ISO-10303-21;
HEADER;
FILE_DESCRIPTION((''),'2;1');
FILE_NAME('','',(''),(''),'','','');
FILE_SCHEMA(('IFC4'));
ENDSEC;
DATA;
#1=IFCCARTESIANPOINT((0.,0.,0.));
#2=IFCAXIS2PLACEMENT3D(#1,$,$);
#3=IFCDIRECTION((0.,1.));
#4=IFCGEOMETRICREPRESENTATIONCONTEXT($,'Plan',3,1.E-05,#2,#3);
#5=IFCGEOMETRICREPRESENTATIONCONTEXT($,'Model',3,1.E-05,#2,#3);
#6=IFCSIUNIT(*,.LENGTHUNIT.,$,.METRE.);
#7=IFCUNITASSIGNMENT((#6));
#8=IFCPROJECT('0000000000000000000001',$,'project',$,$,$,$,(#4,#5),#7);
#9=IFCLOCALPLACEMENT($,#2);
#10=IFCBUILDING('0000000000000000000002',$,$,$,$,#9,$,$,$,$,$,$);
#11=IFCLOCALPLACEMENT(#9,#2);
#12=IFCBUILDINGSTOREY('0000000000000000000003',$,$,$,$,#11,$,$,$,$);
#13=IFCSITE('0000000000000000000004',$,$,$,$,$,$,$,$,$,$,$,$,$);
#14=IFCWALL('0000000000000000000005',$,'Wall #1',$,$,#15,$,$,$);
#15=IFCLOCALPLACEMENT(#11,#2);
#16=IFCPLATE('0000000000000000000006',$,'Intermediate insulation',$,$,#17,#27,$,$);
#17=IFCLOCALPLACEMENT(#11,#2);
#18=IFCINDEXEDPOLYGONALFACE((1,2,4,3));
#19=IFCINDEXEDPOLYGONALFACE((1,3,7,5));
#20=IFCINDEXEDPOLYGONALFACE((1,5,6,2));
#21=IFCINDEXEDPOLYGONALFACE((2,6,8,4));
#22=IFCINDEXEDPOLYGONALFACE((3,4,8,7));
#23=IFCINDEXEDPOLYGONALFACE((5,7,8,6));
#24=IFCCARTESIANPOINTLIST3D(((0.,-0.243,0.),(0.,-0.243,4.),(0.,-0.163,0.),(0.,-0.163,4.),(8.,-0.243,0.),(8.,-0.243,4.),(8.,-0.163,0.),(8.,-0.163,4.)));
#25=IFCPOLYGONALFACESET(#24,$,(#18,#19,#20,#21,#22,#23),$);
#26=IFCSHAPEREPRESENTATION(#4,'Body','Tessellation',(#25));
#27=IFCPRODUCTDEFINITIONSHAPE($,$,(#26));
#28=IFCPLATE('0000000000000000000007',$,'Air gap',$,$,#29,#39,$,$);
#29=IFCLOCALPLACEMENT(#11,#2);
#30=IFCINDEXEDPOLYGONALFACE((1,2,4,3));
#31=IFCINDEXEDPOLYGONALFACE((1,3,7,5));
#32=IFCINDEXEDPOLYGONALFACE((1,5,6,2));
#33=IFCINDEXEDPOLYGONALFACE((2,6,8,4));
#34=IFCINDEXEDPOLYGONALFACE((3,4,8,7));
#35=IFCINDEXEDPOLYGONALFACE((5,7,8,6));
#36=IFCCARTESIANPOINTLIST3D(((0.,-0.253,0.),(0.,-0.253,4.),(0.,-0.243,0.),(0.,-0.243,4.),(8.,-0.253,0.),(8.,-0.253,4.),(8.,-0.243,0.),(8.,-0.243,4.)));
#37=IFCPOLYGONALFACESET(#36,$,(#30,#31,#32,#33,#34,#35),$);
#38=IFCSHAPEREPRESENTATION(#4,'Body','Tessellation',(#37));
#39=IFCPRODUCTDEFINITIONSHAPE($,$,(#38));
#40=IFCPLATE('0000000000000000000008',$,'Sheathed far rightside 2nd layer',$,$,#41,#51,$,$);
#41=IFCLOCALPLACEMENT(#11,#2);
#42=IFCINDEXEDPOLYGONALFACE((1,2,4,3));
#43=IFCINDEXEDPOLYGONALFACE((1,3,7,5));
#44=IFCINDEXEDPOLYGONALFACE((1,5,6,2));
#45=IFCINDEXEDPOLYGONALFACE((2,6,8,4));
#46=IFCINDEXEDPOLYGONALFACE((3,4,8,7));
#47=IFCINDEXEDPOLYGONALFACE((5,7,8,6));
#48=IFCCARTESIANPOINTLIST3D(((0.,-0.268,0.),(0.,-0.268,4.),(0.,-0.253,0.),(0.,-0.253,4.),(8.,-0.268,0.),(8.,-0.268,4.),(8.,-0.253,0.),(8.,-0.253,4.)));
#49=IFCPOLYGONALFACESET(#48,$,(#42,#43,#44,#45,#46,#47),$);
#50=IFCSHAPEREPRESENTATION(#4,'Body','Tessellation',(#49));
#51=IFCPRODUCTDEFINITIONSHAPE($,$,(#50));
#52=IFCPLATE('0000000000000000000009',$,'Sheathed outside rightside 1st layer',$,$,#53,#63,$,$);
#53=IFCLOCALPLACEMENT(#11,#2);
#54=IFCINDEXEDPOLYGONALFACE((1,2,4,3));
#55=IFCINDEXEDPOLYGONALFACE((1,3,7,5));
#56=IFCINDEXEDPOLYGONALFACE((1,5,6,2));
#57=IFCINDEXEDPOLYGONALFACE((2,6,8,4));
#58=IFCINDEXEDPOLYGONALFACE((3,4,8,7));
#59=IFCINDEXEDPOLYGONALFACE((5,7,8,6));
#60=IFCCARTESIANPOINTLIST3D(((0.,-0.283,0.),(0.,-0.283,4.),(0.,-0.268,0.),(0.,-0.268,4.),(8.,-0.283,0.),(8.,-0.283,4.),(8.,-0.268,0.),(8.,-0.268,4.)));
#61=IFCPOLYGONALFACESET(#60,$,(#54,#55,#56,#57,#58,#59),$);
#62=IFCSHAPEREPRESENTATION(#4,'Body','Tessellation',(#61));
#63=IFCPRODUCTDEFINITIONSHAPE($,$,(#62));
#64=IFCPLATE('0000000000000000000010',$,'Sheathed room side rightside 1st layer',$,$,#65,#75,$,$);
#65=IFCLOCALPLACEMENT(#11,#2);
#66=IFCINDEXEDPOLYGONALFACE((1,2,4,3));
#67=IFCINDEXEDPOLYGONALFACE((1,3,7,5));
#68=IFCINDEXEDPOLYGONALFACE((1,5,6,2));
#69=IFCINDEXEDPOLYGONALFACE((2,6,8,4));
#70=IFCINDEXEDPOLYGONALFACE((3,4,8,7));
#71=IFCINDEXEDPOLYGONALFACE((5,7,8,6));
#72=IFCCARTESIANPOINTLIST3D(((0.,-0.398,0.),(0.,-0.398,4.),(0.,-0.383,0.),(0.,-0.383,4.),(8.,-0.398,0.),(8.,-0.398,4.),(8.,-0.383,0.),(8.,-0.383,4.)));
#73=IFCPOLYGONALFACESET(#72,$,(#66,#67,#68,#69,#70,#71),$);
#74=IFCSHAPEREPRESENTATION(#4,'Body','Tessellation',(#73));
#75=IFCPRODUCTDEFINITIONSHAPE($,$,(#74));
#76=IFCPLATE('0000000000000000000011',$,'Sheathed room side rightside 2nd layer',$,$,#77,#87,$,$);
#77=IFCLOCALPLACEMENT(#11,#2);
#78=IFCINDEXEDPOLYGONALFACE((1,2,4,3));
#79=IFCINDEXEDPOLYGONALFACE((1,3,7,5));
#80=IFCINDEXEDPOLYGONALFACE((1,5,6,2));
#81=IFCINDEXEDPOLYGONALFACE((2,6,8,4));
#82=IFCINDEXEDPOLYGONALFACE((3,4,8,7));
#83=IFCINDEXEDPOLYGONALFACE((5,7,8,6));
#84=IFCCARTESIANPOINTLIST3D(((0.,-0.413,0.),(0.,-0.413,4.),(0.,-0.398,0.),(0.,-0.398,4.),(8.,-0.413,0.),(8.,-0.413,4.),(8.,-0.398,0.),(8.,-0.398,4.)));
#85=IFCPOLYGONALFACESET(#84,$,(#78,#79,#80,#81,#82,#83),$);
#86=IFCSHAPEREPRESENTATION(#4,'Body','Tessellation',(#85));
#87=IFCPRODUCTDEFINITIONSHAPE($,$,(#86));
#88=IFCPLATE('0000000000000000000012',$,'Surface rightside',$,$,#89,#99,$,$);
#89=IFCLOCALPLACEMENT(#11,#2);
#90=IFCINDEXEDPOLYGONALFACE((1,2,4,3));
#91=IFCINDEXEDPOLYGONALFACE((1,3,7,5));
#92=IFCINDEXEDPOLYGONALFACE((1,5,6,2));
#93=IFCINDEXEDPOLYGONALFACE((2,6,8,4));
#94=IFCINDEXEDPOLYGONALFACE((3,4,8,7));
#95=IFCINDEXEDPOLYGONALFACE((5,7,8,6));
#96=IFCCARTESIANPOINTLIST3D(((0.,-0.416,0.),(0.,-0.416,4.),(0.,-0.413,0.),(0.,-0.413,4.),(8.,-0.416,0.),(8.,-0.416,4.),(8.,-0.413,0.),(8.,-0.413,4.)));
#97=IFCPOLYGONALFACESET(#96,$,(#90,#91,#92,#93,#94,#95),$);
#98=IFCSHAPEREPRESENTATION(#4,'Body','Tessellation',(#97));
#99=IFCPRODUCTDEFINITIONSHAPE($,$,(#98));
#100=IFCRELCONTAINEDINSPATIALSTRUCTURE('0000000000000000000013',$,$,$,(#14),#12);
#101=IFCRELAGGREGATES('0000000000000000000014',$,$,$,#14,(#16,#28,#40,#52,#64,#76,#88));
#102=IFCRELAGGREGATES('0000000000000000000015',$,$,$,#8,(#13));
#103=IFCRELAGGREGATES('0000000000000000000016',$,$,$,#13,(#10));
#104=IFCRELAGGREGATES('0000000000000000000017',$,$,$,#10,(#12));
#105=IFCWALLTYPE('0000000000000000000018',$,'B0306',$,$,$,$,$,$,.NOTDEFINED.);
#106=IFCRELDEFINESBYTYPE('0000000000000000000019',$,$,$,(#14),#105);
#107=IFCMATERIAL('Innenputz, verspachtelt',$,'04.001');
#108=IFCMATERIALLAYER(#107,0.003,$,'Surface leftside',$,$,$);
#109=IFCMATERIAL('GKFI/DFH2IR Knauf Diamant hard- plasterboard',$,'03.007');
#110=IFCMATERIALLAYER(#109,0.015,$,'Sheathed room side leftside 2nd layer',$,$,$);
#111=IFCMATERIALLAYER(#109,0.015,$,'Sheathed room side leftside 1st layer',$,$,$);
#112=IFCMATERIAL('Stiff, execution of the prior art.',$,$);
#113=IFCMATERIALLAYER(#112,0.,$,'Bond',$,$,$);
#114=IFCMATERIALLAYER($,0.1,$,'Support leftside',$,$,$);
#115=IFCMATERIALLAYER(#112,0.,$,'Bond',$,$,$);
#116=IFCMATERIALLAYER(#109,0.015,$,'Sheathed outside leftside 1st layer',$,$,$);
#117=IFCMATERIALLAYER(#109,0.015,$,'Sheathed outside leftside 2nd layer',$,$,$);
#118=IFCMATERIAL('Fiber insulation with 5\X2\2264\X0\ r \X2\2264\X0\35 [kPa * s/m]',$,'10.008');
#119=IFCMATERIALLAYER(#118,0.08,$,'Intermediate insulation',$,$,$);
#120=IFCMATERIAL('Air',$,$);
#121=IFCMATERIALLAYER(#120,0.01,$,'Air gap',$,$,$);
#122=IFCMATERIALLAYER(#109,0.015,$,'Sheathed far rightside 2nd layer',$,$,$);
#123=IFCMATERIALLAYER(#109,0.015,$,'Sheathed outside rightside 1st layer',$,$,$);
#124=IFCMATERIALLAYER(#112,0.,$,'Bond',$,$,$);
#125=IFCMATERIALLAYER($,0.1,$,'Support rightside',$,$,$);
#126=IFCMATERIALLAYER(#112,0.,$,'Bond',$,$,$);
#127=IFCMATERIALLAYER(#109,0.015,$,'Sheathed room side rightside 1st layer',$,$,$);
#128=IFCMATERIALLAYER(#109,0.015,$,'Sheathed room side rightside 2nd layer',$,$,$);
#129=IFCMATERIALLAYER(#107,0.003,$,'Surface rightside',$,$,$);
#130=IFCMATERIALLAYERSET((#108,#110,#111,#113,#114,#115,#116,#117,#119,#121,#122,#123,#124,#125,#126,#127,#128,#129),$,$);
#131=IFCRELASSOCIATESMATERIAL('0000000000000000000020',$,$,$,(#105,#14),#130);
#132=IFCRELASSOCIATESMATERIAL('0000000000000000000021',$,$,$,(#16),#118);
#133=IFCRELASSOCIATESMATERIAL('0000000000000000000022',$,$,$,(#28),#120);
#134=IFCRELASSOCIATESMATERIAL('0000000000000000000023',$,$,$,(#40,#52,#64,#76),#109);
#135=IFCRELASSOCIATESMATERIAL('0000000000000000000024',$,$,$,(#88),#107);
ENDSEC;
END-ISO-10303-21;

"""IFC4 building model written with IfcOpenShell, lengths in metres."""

from ifc_helpers import new_model, si_unit, direction, frame, frame_2d, origin, place, context, project, spatial, rectangle, extrude, material, layer, layer_set, type_object, element, aggregate, save


model = new_model("IFC4")

# Units and contexts
plan_context = context("Plan", 3, precision=1e-05, world=origin(), true_north=direction((0.0, 1.0)))
model_context = context("Model", 3, precision=1e-05, world=origin(), true_north=direction((0.0, 1.0)))
ifc_project = project(units=[si_unit("LENGTHUNIT", "METRE")], contexts=[plan_context, model_context])

# Site, building, storey
site = spatial("IfcSite", under=ifc_project)
building_placement = place(None, origin())
building = spatial("IfcBuilding", under=site, at=building_placement)
storey_placement = place(building_placement, origin())
storey = spatial("IfcBuildingStorey", under=building, at=storey_placement)

# Wall, plates
ifc_material_1 = material(Name="Innenputz, verspachtelt", Category="04.001")
ifc_layer_1 = layer(ifc_material_1, 0.003, Name="Surface leftside")
ifc_material_2 = material(Name="GKFI/DFH2IR Knauf Diamant hard- plasterboard", Category="03.007")
ifc_layer_2 = layer(ifc_material_2, 0.015, Name="Sheathed room side leftside 2nd layer")
ifc_layer_3 = layer(ifc_material_2, 0.015, Name="Sheathed room side leftside 1st layer")
ifc_material_3 = material(Name="Stiff, execution of the prior art.")
ifc_layer_4 = layer(ifc_material_3, 0.0, Name="Bond")
ifc_layer_5 = layer(None, 0.1, Name="Support leftside")
ifc_layer_6 = layer(ifc_material_3, 0.0, Name="Bond")
ifc_layer_7 = layer(ifc_material_2, 0.015, Name="Sheathed outside leftside 1st layer")
ifc_layer_8 = layer(ifc_material_2, 0.015, Name="Sheathed outside leftside 2nd layer")
ifc_material_4 = material(Name="Fiber insulation with 5≤ r ≤35 [kPa * s/m]", Category="10.008")
ifc_layer_9 = layer(ifc_material_4, 0.08, Name="Intermediate insulation")
ifc_material_5 = material(Name="Air")
ifc_layer_10 = layer(ifc_material_5, 0.01, Name="Air gap")
ifc_layer_11 = layer(ifc_material_2, 0.015, Name="Sheathed far rightside 2nd layer")
ifc_layer_12 = layer(ifc_material_2, 0.015, Name="Sheathed outside rightside 1st layer")
ifc_layer_13 = layer(ifc_material_3, 0.0, Name="Bond")
ifc_layer_14 = layer(None, 0.1, Name="Support rightside")
ifc_layer_15 = layer(ifc_material_3, 0.0, Name="Bond")
ifc_layer_16 = layer(ifc_material_2, 0.015, Name="Sheathed room side rightside 1st layer")
ifc_layer_17 = layer(ifc_material_2, 0.015, Name="Sheathed room side rightside 2nd layer")
ifc_layer_18 = layer(ifc_material_1, 0.003, Name="Surface rightside")
ifc_layer_set = layer_set([ifc_layer_1, ifc_layer_2, ifc_layer_3, ifc_layer_4, ifc_layer_5, ifc_layer_6, ifc_layer_7, ifc_layer_8, ifc_layer_9, ifc_layer_10, ifc_layer_11, ifc_layer_12, ifc_layer_13, ifc_layer_14, ifc_layer_15, ifc_layer_16, ifc_layer_17, ifc_layer_18])
wall_type = type_object("IfcWallType", Name="B0306", PredefinedType="NOTDEFINED", material=ifc_layer_set)
wall_placement = place(None, frame((0.0, 0.0, 0.0), z_axis=(0.0, -1.0, 0.0), x_axis=(1.0, 0.0, 0.0)))
wall = element("IfcWall", 1, at=wall_placement, inside=storey, type_object=wall_type, material=ifc_layer_set, Name="Wall #1")
plate_1_placement = place(wall_placement, origin())
plate_1 = element("IfcPlate", 2, at=plate_1_placement, material=ifc_material_4, Name="Intermediate insulation", context=plan_context, shape_type="SweptSolid", body=[
    extrude(rectangle(XDim=8.0, YDim=4.0, at=frame_2d((4.0, 2.0), x_axis=(1.0, 0.0))), frame((0.0, 0.0, 0.163), z_axis=(0.0, 0.0, 1.0), x_axis=(1.0, 0.0, 0.0)), (0.0, 0.0, 1.0), 0.08),
])
plate_2_placement = place(wall_placement, origin())
plate_2 = element("IfcPlate", 3, at=plate_2_placement, material=ifc_material_5, Name="Air gap", context=plan_context, shape_type="SweptSolid", body=[
    extrude(rectangle(XDim=8.0, YDim=4.0, at=frame_2d((4.0, 2.0), x_axis=(1.0, 0.0))), frame((0.0, 0.0, 0.243), z_axis=(0.0, 0.0, 1.0), x_axis=(1.0, 0.0, 0.0)), (0.0, 0.0, 1.0), 0.01),
])
plate_3_placement = place(wall_placement, origin())
plate_3 = element("IfcPlate", 4, at=plate_3_placement, material=ifc_material_2, Name="Sheathed far rightside 2nd layer", context=plan_context, shape_type="SweptSolid", body=[
    extrude(rectangle(XDim=8.0, YDim=4.0, at=frame_2d((4.0, 2.0), x_axis=(1.0, 0.0))), frame((0.0, 0.0, 0.253), z_axis=(0.0, 0.0, 1.0), x_axis=(1.0, 0.0, 0.0)), (0.0, 0.0, 1.0), 0.015),
])
plate_4_placement = place(wall_placement, origin())
plate_4 = element("IfcPlate", 5, at=plate_4_placement, material=ifc_material_2, Name="Sheathed outside rightside 1st layer", context=plan_context, shape_type="SweptSolid", body=[
    extrude(rectangle(XDim=8.0, YDim=4.0, at=frame_2d((4.0, 2.0), x_axis=(1.0, 0.0))), frame((0.0, 0.0, 0.268), z_axis=(0.0, 0.0, 1.0), x_axis=(1.0, 0.0, 0.0)), (0.0, 0.0, 1.0), 0.015),
])
plate_5_placement = place(wall_placement, origin())
plate_5 = element("IfcPlate", 6, at=plate_5_placement, material=ifc_material_2, Name="Sheathed room side rightside 1st layer", context=plan_context, shape_type="SweptSolid", body=[
    extrude(rectangle(XDim=8.0, YDim=4.0, at=frame_2d((4.0, 2.0), x_axis=(1.0, 0.0))), frame((0.0, 0.0, 0.383), z_axis=(0.0, 0.0, 1.0), x_axis=(1.0, 0.0, 0.0)), (0.0, 0.0, 1.0), 0.015),
])
plate_6_placement = place(wall_placement, origin())
plate_6 = element("IfcPlate", 7, at=plate_6_placement, material=ifc_material_2, Name="Sheathed room side rightside 2nd layer", context=plan_context, shape_type="SweptSolid", body=[
    extrude(rectangle(XDim=8.0, YDim=4.0, at=frame_2d((4.0, 2.0), x_axis=(1.0, 0.0))), frame((0.0, 0.0, 0.398), z_axis=(0.0, 0.0, 1.0), x_axis=(1.0, 0.0, 0.0)), (0.0, 0.0, 1.0), 0.015),
])
plate_7_placement = place(wall_placement, origin())
plate_7 = element("IfcPlate", 8, at=plate_7_placement, material=ifc_material_1, Name="Surface rightside", context=plan_context, shape_type="SweptSolid", body=[
    extrude(rectangle(XDim=8.0, YDim=4.0, at=frame_2d((4.0, 2.0), x_axis=(1.0, 0.0))), frame((0.0, 0.0, 0.413), z_axis=(0.0, 0.0, 1.0), x_axis=(1.0, 0.0, 0.0)), (0.0, 0.0, 1.0), 0.003),
])
aggregate(wall, [plate_1, plate_2, plate_3, plate_4, plate_5, plate_6, plate_7])

save(model, "model.ifc")
